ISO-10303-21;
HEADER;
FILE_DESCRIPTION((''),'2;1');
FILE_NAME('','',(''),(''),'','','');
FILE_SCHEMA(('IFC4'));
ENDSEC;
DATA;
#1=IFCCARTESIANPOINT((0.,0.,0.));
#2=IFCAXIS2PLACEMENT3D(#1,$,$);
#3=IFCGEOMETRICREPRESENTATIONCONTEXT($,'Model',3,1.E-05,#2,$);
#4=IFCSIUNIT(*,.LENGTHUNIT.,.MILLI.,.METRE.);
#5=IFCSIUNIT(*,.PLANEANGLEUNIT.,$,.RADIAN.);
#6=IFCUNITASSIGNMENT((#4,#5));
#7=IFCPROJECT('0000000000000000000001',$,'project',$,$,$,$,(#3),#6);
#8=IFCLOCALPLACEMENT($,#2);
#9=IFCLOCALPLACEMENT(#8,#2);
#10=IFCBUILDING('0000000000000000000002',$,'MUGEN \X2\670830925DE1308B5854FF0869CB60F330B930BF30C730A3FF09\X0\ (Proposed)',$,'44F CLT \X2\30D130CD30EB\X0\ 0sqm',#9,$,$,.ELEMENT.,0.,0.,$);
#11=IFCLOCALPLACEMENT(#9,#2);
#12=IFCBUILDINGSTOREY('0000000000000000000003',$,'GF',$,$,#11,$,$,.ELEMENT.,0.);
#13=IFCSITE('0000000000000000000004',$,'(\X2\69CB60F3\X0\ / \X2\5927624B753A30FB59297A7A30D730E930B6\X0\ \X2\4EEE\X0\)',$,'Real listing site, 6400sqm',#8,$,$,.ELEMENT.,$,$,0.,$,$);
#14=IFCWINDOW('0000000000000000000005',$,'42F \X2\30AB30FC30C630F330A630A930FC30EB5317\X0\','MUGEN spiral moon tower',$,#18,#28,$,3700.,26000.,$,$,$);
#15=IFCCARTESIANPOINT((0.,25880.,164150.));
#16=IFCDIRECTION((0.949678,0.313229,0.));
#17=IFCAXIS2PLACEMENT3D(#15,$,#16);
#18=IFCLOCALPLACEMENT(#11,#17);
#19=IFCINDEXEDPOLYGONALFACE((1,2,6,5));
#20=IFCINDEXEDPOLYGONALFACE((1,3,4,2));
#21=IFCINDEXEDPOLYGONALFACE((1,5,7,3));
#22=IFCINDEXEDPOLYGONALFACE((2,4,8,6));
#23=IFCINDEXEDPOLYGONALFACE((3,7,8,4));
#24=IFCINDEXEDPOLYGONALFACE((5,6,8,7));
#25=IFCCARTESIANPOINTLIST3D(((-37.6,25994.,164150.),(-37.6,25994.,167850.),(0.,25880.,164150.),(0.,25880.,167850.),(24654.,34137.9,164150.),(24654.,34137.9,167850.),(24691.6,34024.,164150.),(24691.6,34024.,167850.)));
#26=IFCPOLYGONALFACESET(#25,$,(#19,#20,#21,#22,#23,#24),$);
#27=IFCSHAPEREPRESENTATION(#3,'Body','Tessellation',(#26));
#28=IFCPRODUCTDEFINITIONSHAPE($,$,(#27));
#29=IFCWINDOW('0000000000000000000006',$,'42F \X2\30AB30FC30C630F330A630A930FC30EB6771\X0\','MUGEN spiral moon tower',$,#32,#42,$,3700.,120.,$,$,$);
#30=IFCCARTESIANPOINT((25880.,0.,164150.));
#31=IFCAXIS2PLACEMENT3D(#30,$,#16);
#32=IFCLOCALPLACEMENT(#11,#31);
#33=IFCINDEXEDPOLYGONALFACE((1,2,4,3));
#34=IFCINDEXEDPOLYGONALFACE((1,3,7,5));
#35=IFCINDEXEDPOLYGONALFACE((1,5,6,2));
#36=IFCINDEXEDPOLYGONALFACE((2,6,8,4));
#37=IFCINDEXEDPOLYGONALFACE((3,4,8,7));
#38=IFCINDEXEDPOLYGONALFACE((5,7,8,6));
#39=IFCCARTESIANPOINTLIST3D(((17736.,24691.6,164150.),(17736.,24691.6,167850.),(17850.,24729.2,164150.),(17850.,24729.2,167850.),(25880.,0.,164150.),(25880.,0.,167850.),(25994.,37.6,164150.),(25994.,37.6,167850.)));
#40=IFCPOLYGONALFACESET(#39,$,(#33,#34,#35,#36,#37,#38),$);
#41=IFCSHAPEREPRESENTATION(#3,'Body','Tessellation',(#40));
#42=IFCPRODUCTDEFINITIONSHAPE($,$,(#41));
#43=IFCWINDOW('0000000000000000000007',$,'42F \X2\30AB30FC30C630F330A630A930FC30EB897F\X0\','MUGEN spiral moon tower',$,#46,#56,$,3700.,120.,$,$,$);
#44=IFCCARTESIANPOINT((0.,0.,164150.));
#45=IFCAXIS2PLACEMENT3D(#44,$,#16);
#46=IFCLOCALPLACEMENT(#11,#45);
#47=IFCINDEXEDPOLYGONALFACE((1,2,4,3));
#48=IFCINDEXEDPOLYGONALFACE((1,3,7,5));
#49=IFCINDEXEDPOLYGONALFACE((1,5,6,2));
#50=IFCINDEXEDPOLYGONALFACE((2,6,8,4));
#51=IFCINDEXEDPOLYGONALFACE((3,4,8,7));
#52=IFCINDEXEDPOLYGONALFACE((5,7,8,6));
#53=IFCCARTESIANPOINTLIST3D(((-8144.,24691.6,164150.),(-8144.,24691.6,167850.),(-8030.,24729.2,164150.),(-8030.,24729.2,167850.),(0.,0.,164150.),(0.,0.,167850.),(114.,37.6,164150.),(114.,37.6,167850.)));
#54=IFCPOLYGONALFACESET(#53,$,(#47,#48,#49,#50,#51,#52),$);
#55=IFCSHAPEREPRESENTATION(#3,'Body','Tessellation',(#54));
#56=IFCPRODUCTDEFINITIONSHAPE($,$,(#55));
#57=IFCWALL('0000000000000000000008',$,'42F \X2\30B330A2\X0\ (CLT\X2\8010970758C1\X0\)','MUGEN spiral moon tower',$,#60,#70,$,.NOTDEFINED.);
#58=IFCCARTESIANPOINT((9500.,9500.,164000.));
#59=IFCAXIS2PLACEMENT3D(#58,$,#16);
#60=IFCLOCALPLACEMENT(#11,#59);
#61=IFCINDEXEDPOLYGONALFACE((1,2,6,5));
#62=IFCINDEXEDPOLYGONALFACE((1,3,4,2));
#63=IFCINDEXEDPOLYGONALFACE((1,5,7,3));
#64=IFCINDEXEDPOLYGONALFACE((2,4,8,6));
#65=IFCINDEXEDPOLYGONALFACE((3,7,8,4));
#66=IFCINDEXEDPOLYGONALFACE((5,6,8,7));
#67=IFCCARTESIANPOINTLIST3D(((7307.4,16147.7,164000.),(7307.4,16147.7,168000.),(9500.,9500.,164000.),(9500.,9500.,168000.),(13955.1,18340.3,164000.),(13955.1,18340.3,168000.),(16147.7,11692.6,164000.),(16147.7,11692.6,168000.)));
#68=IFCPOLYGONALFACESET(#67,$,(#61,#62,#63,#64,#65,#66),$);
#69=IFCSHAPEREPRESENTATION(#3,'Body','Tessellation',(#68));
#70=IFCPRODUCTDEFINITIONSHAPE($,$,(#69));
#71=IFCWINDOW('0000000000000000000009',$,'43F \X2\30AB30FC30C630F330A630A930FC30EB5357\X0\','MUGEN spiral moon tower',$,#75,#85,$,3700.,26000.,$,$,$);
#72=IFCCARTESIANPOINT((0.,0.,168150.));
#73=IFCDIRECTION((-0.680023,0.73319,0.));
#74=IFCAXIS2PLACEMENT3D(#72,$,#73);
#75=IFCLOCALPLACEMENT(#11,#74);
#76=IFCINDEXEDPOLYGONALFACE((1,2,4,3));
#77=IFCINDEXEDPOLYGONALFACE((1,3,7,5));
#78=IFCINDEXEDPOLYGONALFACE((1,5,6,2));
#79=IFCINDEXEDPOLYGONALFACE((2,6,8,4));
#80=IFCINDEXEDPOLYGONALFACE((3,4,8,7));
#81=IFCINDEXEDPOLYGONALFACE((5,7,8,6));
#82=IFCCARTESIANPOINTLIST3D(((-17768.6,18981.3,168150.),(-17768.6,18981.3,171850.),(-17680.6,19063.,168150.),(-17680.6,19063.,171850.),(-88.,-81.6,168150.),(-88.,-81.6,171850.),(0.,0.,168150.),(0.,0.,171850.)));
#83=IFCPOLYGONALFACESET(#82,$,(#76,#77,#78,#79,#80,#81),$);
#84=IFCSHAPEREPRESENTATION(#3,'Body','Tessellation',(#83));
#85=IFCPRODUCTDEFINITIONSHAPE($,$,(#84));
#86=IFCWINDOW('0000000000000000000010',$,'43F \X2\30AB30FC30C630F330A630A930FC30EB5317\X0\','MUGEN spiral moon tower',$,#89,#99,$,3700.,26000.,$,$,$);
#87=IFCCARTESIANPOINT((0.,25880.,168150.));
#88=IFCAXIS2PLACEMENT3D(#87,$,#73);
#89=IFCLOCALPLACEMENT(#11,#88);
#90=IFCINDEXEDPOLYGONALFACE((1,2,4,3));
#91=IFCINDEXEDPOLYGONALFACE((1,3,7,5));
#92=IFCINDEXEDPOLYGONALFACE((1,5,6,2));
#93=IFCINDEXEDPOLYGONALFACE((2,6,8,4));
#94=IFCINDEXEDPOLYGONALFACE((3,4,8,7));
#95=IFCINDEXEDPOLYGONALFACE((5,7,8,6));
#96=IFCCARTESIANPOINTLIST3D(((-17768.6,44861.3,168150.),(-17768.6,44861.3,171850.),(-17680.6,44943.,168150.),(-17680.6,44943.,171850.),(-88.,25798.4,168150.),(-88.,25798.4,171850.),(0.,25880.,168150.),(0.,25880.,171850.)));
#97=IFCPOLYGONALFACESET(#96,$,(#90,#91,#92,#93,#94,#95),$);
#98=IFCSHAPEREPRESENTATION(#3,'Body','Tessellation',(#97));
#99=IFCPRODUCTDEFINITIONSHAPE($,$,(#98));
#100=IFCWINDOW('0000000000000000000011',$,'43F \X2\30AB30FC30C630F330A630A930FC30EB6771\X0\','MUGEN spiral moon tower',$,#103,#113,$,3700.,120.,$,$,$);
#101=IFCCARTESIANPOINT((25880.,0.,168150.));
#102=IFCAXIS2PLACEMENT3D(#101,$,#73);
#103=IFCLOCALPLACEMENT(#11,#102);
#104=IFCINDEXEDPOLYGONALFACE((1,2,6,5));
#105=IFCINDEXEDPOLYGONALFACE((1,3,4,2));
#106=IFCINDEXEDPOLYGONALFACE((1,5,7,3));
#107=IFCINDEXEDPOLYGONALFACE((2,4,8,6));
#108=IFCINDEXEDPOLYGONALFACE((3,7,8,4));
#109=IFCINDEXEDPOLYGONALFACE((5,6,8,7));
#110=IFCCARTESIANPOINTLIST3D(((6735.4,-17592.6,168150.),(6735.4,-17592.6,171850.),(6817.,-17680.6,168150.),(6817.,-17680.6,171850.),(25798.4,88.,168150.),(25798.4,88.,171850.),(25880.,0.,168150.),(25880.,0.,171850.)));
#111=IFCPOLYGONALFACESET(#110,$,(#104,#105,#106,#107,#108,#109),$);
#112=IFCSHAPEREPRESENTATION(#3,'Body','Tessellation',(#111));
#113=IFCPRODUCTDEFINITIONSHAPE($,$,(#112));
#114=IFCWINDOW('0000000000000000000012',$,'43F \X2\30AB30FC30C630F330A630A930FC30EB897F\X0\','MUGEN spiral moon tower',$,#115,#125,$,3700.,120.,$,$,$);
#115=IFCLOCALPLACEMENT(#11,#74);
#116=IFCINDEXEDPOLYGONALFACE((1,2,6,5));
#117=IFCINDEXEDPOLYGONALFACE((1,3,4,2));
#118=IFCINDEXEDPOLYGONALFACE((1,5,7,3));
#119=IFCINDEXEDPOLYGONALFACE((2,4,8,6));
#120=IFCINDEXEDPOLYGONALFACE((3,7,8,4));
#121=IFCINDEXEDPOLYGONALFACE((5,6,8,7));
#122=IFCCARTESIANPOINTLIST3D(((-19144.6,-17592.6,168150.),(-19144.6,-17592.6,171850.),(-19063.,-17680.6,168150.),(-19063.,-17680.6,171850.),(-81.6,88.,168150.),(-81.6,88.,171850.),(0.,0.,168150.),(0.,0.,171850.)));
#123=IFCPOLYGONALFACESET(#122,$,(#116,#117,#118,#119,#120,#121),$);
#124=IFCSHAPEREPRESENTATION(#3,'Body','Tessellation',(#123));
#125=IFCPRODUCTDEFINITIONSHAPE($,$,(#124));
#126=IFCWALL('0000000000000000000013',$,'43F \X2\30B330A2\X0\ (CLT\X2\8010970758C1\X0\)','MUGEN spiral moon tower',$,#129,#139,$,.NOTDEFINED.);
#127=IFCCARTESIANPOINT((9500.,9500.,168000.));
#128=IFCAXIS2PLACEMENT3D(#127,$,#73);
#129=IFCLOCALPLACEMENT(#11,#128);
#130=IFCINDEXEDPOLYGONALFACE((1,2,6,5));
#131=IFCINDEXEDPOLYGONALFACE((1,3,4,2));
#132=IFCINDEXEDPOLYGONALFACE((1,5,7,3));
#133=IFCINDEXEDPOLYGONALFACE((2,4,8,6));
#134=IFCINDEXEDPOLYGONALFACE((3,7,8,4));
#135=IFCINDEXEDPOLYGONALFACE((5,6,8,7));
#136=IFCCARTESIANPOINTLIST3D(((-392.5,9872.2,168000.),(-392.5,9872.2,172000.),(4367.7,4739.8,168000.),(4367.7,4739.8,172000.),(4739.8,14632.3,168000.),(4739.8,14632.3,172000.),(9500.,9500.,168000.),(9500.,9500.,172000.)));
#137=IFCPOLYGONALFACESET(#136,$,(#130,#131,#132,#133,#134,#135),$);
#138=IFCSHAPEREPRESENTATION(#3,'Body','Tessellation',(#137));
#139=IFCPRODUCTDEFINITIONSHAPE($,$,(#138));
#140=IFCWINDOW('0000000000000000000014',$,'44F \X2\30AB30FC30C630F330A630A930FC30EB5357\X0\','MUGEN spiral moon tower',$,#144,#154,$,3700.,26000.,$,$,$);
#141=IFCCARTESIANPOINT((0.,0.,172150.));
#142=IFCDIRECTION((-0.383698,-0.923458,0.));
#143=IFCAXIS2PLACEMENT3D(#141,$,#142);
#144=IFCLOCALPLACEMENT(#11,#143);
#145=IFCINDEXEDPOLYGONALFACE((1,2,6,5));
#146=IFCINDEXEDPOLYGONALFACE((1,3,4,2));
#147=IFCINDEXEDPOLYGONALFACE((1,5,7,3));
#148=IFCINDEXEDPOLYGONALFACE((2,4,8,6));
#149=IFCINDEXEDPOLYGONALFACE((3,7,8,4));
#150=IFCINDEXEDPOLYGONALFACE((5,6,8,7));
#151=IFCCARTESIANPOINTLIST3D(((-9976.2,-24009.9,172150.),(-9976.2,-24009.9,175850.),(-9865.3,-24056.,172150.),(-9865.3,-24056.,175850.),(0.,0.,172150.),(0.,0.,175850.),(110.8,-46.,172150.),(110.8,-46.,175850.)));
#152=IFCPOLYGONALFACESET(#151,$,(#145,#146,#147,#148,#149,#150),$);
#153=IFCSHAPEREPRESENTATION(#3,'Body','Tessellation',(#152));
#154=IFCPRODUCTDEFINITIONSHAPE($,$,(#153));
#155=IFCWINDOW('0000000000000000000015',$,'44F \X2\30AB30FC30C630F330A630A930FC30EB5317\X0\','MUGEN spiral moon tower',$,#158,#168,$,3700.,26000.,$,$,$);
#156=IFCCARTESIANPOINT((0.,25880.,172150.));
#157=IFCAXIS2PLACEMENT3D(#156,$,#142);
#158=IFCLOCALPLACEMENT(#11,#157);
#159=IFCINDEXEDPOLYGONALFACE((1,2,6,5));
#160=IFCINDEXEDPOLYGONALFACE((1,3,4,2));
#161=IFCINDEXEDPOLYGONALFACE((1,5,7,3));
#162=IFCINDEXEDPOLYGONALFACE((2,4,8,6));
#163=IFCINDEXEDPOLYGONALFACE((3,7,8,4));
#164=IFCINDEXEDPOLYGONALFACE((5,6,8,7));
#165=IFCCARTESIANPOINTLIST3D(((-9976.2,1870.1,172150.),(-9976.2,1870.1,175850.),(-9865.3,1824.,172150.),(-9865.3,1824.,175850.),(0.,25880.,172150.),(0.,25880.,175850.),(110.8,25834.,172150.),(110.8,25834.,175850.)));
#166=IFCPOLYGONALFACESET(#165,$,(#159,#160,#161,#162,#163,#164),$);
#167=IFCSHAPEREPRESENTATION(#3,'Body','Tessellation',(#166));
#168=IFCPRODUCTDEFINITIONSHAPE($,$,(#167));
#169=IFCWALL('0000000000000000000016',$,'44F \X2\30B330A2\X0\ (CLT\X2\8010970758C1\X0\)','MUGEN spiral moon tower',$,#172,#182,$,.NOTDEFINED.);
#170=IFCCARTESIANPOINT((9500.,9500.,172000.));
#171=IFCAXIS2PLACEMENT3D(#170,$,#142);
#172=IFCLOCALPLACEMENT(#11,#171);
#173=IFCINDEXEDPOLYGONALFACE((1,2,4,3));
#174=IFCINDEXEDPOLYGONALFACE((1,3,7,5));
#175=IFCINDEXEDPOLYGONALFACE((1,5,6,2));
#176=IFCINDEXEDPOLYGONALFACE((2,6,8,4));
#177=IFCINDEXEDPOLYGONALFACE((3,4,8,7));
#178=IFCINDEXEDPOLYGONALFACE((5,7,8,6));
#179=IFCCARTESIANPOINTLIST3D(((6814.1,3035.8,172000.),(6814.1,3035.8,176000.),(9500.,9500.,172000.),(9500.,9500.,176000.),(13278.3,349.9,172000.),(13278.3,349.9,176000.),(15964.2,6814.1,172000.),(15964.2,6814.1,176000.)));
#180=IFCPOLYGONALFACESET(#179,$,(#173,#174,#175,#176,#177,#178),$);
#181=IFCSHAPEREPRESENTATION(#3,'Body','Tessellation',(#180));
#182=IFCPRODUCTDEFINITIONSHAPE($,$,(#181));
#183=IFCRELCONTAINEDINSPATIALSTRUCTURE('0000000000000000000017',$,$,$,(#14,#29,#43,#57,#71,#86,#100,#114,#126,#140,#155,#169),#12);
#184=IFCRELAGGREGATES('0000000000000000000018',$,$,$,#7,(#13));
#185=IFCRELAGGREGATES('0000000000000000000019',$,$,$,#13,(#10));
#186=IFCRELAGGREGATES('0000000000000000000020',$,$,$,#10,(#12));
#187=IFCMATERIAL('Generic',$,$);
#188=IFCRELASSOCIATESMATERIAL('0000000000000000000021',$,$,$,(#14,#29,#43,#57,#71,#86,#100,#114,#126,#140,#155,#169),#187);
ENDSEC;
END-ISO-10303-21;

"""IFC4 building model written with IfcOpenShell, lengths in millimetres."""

from ifc_helpers import new_model, si_unit, frame, frame_2d, origin, place, context, project, spatial, rectangle, extrude, material, element, save


model = new_model("IFC4")

# Units and contexts
model_context = context("Model", 3, precision=1e-05, world=origin())
ifc_project = project(units=[si_unit("LENGTHUNIT", "METRE", prefix="MILLI"), si_unit("PLANEANGLEUNIT", "RADIAN")], contexts=[model_context])

# Site, building, storey
site_placement = place(None, origin())
site = spatial("IfcSite", under=ifc_project, at=site_placement, Name="(構想 / 大手町・天空プラザ 仮)", ObjectType="Real listing site, 6400sqm", CompositionType="ELEMENT", RefElevation=0.0)
building_placement = place(site_placement, origin())
building = spatial("IfcBuilding", under=site, at=building_placement, Name="MUGEN 月を巡る塔（構想スタディ） (Proposed)", ObjectType="44F CLT パネル 0sqm", CompositionType="ELEMENT", ElevationOfRefHeight=0.0, ElevationOfTerrain=0.0)
storey_placement = place(building_placement, origin())
storey = spatial("IfcBuildingStorey", under=building, at=storey_placement, Name="GF", CompositionType="ELEMENT", Elevation=0.0)

# Shared definitions
ifc_material = material(Name="Generic")

# Windows
window_1_placement = place(storey_placement, frame((0.0, 25880.0, 164150.0), x_axis=(0.949678, 0.313229, 0.0)))
element("IfcWindow", 1, at=window_1_placement, inside=storey, material=ifc_material, Name="42F カーテンウォール北", Description="MUGEN spiral moon tower", OverallHeight=3700.0, OverallWidth=26000.0, context=model_context, shape_type="SweptSolid", body=[
    extrude(rectangle(XDim=26000.0, YDim=120.0, at=frame_2d((13000.0, 60.0))), frame((0.0, 25880.0, 164150.0), x_axis=(0.949678, 0.313229, 0.0)), (0.0, 0.0, 1.0), 3700.0),
])
window_2_placement = place(storey_placement, frame((25880.0, 0.0, 164150.0), x_axis=(0.949678, 0.313229, 0.0)))
element("IfcWindow", 2, at=window_2_placement, inside=storey, material=ifc_material, Name="42F カーテンウォール東", Description="MUGEN spiral moon tower", OverallHeight=3700.0, OverallWidth=120.0, context=model_context, shape_type="SweptSolid", body=[
    extrude(rectangle(XDim=120.0, YDim=26000.0, at=frame_2d((60.0, 13000.0))), frame((25880.0, 0.0, 164150.0), x_axis=(0.949678, 0.313229, 0.0)), (0.0, 0.0, 1.0), 3700.0),
])
window_3_placement = place(storey_placement, frame((0.0, 0.0, 164150.0), x_axis=(0.949678, 0.313229, 0.0)))
element("IfcWindow", 3, at=window_3_placement, inside=storey, material=ifc_material, Name="42F カーテンウォール西", Description="MUGEN spiral moon tower", OverallHeight=3700.0, OverallWidth=120.0, context=model_context, shape_type="SweptSolid", body=[
    extrude(rectangle(XDim=120.0, YDim=26000.0, at=frame_2d((60.0, 13000.0))), frame((0.0, 0.0, 164150.0), x_axis=(0.949678, 0.313229, 0.0)), (0.0, 0.0, 1.0), 3700.0),
])

# Wall
wall_1_placement = place(storey_placement, frame((9500.0, 9500.0, 164000.0), x_axis=(0.949678, 0.313229, 0.0)))
element("IfcWall", 4, at=wall_1_placement, inside=storey, material=ifc_material, Name="42F コア (CLT耐震壁)", Description="MUGEN spiral moon tower", PredefinedType="NOTDEFINED", context=model_context, shape_type="SweptSolid", body=[
    extrude(rectangle(XDim=7000.0, YDim=7000.0, at=frame_2d((3500.0, 3500.0))), frame((9500.0, 9500.0, 164000.0), x_axis=(0.949678, 0.313229, 0.0)), (0.0, 0.0, 1.0), 4000.0),
])

# Windows
window_4_placement = place(storey_placement, frame((0.0, 0.0, 168150.0), x_axis=(-0.680023, 0.73319, 0.0)))
element("IfcWindow", 5, at=window_4_placement, inside=storey, material=ifc_material, Name="43F カーテンウォール南", Description="MUGEN spiral moon tower", OverallHeight=3700.0, OverallWidth=26000.0, context=model_context, shape_type="SweptSolid", body=[
    extrude(rectangle(XDim=26000.0, YDim=120.0, at=frame_2d((13000.0, 60.0))), frame((0.0, 0.0, 168150.0), x_axis=(-0.680023, 0.73319, 0.0)), (0.0, 0.0, 1.0), 3700.0),
])
window_5_placement = place(storey_placement, frame((0.0, 25880.0, 168150.0), x_axis=(-0.680023, 0.73319, 0.0)))
element("IfcWindow", 6, at=window_5_placement, inside=storey, material=ifc_material, Name="43F カーテンウォール北", Description="MUGEN spiral moon tower", OverallHeight=3700.0, OverallWidth=26000.0, context=model_context, shape_type="SweptSolid", body=[
    extrude(rectangle(XDim=26000.0, YDim=120.0, at=frame_2d((13000.0, 60.0))), frame((0.0, 25880.0, 168150.0), x_axis=(-0.680023, 0.73319, 0.0)), (0.0, 0.0, 1.0), 3700.0),
])
window_6_placement = place(storey_placement, frame((25880.0, 0.0, 168150.0), x_axis=(-0.680023, 0.73319, 0.0)))
element("IfcWindow", 7, at=window_6_placement, inside=storey, material=ifc_material, Name="43F カーテンウォール東", Description="MUGEN spiral moon tower", OverallHeight=3700.0, OverallWidth=120.0, context=model_context, shape_type="SweptSolid", body=[
    extrude(rectangle(XDim=120.0, YDim=26000.0, at=frame_2d((60.0, 13000.0))), frame((25880.0, 0.0, 168150.0), x_axis=(-0.680023, 0.73319, 0.0)), (0.0, 0.0, 1.0), 3700.0),
])
window_7_placement = place(storey_placement, frame((0.0, 0.0, 168150.0), x_axis=(-0.680023, 0.73319, 0.0)))
element("IfcWindow", 8, at=window_7_placement, inside=storey, material=ifc_material, Name="43F カーテンウォール西", Description="MUGEN spiral moon tower", OverallHeight=3700.0, OverallWidth=120.0, context=model_context, shape_type="SweptSolid", body=[
    extrude(rectangle(XDim=120.0, YDim=26000.0, at=frame_2d((60.0, 13000.0))), frame((0.0, 0.0, 168150.0), x_axis=(-0.680023, 0.73319, 0.0)), (0.0, 0.0, 1.0), 3700.0),
])

# Wall
wall_2_placement = place(storey_placement, frame((9500.0, 9500.0, 168000.0), x_axis=(-0.680023, 0.73319, 0.0)))
element("IfcWall", 9, at=wall_2_placement, inside=storey, material=ifc_material, Name="43F コア (CLT耐震壁)", Description="MUGEN spiral moon tower", PredefinedType="NOTDEFINED", context=model_context, shape_type="SweptSolid", body=[
    extrude(rectangle(XDim=7000.0, YDim=7000.0, at=frame_2d((3500.0, 3500.0))), frame((9500.0, 9500.0, 168000.0), x_axis=(-0.680023, 0.73319, 0.0)), (0.0, 0.0, 1.0), 4000.0),
])

# Windows
window_8_placement = place(storey_placement, frame((0.0, 0.0, 172150.0), x_axis=(-0.383698, -0.923458, 0.0)))
element("IfcWindow", 10, at=window_8_placement, inside=storey, material=ifc_material, Name="44F カーテンウォール南", Description="MUGEN spiral moon tower", OverallHeight=3700.0, OverallWidth=26000.0, context=model_context, shape_type="SweptSolid", body=[
    extrude(rectangle(XDim=26000.0, YDim=120.0, at=frame_2d((13000.0, 60.0))), frame((0.0, 0.0, 172150.0), x_axis=(-0.383698, -0.923458, 0.0)), (0.0, 0.0, 1.0), 3700.0),
])
window_9_placement = place(storey_placement, frame((0.0, 25880.0, 172150.0), x_axis=(-0.383698, -0.923458, 0.0)))
element("IfcWindow", 11, at=window_9_placement, inside=storey, material=ifc_material, Name="44F カーテンウォール北", Description="MUGEN spiral moon tower", OverallHeight=3700.0, OverallWidth=26000.0, context=model_context, shape_type="SweptSolid", body=[
    extrude(rectangle(XDim=26000.0, YDim=120.0, at=frame_2d((13000.0, 60.0))), frame((0.0, 25880.0, 172150.0), x_axis=(-0.383698, -0.923458, 0.0)), (0.0, 0.0, 1.0), 3700.0),
])

# Wall
wall_3_placement = place(storey_placement, frame((9500.0, 9500.0, 172000.0), x_axis=(-0.383698, -0.923458, 0.0)))
element("IfcWall", 12, at=wall_3_placement, inside=storey, material=ifc_material, Name="44F コア (CLT耐震壁)", Description="MUGEN spiral moon tower", PredefinedType="NOTDEFINED", context=model_context, shape_type="SweptSolid", body=[
    extrude(rectangle(XDim=7000.0, YDim=7000.0, at=frame_2d((3500.0, 3500.0))), frame((9500.0, 9500.0, 172000.0), x_axis=(-0.383698, -0.923458, 0.0)), (0.0, 0.0, 1.0), 4000.0),
])

save(model, "model.ifc")
